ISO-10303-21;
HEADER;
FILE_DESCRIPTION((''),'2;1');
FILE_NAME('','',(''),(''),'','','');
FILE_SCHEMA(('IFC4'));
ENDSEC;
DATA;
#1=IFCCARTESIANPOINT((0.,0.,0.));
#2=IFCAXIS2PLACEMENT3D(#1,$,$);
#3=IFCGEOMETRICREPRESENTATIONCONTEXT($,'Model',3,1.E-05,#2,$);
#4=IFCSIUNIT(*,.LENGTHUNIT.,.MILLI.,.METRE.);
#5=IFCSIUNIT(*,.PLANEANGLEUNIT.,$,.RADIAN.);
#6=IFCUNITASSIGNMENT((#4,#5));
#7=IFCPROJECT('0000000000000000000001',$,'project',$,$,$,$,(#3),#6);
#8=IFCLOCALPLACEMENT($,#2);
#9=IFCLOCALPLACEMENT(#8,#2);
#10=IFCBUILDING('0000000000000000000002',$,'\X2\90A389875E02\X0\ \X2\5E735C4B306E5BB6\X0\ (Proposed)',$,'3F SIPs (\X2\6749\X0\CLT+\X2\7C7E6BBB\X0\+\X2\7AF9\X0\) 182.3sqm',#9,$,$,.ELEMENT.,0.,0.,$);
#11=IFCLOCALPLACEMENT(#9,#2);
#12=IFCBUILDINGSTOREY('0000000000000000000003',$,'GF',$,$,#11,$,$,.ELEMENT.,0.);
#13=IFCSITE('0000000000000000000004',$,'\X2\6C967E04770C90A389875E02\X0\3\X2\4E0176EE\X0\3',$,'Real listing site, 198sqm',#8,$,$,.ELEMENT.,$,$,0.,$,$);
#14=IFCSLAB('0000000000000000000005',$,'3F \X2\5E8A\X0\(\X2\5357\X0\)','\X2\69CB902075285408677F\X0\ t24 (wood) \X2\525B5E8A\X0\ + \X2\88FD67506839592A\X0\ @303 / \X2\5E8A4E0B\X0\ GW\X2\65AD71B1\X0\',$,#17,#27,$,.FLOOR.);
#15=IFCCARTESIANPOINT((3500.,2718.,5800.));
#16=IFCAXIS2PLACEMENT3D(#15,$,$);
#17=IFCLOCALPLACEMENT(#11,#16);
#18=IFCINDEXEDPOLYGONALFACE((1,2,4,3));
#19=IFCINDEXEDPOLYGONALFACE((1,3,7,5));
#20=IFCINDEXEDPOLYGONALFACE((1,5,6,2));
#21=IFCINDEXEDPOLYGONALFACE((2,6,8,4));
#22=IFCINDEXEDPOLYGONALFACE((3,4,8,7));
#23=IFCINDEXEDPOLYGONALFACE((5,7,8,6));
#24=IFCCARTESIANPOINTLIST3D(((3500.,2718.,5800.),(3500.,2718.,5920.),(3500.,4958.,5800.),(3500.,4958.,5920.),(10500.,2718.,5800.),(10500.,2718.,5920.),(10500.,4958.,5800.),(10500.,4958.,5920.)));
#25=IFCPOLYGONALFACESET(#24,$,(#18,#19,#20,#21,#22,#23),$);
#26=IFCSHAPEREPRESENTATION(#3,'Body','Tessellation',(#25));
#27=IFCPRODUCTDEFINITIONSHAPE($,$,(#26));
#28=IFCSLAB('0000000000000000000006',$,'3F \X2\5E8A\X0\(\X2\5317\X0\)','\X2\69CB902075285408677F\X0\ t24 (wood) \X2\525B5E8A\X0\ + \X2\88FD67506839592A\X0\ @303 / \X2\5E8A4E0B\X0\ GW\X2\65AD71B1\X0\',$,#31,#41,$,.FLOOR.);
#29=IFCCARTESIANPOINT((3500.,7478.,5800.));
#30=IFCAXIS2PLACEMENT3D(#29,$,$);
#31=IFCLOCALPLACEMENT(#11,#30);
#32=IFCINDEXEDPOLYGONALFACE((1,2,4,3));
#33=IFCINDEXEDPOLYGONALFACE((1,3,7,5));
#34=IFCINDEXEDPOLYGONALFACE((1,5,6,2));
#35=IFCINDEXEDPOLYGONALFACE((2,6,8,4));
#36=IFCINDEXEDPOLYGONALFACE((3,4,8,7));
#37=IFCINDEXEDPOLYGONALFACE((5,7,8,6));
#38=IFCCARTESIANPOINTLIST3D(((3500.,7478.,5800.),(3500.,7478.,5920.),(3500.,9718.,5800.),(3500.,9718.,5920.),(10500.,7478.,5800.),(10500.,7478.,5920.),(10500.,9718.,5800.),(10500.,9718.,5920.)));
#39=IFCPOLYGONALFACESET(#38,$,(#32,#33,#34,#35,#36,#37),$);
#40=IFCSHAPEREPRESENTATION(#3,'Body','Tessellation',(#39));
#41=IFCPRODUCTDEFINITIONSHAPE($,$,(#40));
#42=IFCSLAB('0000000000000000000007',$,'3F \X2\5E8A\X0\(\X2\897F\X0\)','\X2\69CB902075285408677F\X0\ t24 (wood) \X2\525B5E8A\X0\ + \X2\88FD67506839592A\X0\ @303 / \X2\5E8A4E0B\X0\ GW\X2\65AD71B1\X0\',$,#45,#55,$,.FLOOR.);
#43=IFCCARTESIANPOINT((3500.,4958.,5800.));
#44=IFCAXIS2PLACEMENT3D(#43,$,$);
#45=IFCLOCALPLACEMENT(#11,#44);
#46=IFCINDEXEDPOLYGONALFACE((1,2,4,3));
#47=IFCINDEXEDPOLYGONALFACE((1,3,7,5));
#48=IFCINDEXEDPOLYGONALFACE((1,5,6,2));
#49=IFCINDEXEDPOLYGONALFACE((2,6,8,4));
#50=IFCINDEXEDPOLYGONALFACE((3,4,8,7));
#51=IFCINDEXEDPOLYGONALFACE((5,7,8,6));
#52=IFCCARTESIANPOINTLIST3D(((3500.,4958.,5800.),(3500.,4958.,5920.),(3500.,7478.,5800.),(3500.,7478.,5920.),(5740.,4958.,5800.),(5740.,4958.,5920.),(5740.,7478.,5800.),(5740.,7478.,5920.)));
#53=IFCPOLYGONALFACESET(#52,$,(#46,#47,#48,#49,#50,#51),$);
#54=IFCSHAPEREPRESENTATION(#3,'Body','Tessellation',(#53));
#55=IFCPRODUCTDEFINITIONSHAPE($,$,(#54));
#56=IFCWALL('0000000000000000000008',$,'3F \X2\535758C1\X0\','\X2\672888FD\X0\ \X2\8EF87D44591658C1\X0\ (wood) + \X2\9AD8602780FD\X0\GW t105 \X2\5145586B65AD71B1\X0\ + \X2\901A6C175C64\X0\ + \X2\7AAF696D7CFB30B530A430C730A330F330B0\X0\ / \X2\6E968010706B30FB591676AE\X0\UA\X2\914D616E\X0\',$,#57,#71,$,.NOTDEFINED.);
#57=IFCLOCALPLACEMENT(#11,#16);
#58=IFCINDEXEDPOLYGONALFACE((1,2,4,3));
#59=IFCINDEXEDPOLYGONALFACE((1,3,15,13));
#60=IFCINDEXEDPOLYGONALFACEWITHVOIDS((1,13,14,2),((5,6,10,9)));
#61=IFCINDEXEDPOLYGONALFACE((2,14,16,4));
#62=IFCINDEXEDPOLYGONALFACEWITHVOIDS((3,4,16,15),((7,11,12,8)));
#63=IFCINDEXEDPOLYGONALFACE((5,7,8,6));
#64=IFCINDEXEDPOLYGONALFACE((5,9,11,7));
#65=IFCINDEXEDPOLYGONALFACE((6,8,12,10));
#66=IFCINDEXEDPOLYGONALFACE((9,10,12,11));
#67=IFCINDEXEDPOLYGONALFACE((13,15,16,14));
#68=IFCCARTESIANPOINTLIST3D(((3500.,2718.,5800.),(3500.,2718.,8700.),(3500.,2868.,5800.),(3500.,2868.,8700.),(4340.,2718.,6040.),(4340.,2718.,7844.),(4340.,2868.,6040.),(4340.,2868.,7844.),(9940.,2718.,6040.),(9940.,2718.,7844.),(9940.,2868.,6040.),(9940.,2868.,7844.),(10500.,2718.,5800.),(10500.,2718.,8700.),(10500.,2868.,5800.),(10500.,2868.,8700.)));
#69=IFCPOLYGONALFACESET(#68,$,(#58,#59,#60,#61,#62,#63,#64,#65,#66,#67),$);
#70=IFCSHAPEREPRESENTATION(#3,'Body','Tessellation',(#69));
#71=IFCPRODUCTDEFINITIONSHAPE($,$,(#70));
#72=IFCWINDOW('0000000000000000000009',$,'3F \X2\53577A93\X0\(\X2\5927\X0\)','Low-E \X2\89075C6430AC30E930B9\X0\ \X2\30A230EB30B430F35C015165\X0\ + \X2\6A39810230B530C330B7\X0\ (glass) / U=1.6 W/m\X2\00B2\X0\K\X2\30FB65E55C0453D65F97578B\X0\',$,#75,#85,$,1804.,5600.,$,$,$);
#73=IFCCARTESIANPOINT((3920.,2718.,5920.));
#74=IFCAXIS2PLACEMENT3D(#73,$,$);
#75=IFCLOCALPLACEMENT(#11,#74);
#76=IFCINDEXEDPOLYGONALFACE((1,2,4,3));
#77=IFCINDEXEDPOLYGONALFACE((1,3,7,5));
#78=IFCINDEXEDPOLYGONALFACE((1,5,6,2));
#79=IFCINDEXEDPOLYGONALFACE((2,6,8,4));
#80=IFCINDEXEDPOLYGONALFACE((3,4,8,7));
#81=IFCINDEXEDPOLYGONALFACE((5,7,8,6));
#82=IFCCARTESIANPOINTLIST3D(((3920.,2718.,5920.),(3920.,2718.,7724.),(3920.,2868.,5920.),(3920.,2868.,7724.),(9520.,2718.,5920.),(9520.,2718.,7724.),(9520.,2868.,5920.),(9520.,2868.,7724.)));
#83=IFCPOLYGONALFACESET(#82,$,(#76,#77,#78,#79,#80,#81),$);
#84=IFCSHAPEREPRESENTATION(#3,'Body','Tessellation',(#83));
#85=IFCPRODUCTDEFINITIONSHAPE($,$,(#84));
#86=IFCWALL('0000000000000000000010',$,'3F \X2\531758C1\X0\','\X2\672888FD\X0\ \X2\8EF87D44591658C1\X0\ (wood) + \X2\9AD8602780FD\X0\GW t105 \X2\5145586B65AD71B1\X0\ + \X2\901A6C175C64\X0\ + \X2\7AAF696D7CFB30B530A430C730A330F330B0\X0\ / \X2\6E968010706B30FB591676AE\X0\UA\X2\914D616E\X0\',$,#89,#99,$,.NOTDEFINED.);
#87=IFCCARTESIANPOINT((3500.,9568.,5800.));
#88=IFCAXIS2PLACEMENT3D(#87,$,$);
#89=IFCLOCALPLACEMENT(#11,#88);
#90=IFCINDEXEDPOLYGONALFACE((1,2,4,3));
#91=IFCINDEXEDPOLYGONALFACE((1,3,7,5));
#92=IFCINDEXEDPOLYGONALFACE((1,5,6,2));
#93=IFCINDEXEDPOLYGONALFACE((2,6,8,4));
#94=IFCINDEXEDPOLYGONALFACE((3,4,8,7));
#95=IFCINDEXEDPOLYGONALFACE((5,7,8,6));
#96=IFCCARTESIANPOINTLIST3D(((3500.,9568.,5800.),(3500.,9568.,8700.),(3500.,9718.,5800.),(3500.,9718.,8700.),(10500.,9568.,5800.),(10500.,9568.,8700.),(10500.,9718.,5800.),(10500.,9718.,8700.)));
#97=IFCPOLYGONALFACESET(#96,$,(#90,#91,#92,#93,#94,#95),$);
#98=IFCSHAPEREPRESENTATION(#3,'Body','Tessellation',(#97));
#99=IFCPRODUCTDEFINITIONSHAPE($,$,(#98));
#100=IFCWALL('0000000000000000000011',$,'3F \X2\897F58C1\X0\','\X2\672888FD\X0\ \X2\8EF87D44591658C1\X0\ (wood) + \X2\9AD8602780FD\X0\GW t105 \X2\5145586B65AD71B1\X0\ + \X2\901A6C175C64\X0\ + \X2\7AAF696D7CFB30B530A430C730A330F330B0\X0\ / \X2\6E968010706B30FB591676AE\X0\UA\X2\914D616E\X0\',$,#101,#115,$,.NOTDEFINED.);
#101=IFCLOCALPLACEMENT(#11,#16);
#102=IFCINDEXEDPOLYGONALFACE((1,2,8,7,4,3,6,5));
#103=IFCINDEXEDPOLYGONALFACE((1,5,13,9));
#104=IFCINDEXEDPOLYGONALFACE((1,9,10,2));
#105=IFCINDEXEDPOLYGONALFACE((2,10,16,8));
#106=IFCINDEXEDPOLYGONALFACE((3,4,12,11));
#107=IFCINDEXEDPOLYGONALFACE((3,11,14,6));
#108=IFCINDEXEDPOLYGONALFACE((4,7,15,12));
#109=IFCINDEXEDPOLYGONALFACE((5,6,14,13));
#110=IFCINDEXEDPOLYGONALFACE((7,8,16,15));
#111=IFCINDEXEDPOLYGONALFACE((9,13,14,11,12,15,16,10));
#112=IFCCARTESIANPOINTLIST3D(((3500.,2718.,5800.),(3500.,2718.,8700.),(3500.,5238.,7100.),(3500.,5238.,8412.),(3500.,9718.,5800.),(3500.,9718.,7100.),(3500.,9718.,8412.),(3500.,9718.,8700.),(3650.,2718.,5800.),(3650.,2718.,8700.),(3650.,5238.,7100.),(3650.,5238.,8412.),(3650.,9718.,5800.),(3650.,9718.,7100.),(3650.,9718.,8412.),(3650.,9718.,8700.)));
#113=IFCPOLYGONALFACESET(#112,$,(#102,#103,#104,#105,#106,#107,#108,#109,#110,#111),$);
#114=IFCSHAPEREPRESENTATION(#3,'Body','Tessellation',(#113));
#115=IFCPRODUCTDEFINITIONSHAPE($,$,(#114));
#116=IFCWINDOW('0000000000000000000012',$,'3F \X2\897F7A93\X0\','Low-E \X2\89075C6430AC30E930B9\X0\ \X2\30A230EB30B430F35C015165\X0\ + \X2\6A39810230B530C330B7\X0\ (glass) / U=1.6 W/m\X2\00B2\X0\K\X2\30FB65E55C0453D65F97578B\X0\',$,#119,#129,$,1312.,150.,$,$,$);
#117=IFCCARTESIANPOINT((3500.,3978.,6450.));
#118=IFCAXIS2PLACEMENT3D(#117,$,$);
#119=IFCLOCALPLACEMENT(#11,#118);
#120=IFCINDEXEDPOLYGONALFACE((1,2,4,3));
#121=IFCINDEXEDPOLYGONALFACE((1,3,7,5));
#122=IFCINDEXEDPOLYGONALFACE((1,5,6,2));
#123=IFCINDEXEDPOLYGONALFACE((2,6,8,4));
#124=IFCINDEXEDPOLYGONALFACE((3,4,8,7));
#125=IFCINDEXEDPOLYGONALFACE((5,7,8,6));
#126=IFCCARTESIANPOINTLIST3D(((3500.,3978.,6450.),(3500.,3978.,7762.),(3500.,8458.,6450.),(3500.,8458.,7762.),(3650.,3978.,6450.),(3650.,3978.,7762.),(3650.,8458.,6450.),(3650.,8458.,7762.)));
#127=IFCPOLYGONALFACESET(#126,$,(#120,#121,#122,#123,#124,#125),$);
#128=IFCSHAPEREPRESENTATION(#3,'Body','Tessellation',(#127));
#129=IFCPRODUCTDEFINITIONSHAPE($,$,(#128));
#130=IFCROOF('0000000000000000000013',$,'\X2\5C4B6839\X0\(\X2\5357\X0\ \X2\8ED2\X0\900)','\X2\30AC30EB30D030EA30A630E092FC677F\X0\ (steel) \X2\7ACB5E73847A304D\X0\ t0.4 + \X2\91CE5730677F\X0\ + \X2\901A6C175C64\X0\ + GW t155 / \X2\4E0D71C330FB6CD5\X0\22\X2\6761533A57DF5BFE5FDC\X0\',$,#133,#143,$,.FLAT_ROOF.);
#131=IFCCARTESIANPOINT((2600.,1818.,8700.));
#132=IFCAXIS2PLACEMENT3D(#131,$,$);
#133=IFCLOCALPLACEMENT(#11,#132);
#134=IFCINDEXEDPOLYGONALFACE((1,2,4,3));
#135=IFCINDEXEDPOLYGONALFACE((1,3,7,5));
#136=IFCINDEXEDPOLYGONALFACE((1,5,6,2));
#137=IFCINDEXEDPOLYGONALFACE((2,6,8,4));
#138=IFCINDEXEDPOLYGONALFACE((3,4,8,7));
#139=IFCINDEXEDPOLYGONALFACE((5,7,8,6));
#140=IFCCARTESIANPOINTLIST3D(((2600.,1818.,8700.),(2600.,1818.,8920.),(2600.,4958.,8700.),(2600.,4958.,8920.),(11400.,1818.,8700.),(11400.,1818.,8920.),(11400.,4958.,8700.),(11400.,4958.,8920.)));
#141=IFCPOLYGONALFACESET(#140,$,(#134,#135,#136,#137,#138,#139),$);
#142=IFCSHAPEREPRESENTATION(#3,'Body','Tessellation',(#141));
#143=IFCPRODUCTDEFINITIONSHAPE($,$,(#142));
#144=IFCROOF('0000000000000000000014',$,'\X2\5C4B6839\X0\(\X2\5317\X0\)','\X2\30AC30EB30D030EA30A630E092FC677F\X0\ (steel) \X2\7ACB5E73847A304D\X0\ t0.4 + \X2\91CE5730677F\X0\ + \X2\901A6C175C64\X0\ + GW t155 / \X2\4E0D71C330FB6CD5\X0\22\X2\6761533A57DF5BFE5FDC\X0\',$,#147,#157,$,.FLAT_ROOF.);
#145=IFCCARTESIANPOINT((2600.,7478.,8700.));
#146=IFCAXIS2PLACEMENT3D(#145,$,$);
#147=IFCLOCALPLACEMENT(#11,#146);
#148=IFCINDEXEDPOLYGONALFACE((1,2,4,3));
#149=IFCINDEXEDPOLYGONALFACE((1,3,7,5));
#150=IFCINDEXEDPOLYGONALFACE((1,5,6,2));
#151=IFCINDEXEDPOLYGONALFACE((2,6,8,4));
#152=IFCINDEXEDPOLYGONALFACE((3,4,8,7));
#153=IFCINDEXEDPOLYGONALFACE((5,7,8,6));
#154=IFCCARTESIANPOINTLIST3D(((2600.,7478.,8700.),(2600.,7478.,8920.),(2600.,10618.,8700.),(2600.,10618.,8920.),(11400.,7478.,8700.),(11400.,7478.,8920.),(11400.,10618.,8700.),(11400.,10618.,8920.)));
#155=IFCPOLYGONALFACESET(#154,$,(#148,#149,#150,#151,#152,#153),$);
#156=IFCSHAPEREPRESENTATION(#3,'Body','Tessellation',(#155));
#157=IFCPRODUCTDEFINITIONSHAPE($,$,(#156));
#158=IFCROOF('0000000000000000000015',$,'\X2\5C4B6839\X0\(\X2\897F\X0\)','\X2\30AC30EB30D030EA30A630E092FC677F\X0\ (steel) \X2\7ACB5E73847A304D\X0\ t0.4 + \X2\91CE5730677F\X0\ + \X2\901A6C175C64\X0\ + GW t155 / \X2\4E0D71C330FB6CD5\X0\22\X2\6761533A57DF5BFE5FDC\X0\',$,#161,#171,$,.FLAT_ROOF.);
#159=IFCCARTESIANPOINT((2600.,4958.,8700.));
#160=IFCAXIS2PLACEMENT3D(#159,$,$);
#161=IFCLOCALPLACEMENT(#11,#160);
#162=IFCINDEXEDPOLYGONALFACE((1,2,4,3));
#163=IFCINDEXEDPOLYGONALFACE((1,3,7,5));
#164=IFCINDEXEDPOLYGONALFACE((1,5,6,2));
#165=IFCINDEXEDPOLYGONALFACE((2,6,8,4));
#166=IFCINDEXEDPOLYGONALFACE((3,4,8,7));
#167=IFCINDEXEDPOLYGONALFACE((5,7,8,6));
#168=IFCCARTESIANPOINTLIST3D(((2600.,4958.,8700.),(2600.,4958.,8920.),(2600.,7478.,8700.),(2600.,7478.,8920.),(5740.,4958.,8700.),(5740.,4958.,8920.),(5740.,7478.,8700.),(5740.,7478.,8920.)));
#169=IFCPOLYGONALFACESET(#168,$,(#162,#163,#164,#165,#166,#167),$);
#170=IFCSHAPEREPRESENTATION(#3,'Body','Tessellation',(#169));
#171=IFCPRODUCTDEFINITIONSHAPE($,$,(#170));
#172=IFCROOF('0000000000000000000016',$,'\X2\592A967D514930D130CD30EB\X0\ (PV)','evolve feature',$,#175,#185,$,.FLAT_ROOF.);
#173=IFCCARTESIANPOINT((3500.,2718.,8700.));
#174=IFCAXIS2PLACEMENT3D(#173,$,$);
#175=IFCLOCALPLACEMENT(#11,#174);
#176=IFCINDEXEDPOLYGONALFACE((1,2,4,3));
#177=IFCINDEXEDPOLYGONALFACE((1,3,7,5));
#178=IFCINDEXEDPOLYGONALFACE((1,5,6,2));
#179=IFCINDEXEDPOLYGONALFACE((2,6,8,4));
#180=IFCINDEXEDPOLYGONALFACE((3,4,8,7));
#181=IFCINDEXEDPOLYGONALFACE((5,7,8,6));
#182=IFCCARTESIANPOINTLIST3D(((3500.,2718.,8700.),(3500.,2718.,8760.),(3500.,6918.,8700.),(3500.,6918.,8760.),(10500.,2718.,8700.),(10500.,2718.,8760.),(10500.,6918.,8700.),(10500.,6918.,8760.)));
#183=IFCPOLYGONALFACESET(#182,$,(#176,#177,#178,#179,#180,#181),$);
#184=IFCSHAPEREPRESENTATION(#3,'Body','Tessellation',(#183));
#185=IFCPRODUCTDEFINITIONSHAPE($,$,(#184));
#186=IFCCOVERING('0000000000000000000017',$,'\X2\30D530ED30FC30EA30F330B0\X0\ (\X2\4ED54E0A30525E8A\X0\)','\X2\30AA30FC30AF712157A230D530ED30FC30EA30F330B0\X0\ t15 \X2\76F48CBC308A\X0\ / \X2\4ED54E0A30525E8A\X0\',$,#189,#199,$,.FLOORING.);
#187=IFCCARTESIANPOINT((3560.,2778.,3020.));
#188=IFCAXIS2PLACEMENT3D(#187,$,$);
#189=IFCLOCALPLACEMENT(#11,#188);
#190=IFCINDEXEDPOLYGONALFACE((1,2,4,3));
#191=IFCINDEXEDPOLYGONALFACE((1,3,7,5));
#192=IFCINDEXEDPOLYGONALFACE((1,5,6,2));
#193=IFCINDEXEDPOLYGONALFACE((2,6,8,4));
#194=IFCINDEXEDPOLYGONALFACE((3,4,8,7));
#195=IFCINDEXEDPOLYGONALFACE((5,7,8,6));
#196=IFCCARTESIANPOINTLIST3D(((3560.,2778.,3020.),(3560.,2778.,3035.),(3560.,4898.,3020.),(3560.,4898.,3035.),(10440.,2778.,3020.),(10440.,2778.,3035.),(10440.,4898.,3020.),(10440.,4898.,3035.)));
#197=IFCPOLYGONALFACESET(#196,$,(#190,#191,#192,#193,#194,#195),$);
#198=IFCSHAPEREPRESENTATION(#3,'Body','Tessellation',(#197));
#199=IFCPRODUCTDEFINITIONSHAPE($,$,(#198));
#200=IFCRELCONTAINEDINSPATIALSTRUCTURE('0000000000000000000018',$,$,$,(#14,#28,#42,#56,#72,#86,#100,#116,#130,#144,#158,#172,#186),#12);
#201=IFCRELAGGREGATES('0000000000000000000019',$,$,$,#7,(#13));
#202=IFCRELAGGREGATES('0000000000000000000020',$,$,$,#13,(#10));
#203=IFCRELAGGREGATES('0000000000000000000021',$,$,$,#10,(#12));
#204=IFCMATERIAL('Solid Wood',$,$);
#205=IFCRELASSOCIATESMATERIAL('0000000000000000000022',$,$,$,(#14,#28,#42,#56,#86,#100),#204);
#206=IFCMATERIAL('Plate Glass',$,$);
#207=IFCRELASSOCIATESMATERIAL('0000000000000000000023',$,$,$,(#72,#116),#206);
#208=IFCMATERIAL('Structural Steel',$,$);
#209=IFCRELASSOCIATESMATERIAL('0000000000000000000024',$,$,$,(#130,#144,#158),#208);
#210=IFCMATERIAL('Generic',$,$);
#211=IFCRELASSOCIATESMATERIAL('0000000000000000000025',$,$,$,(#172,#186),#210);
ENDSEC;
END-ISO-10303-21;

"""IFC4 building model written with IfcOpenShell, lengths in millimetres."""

from ifc_helpers import new_model, si_unit, frame, frame_2d, origin, place, context, project, spatial, rectangle, extrude, material, element, fill, save


model = new_model("IFC4")

# Units and contexts
model_context = context("Model", 3, precision=1e-05, world=origin())
ifc_project = project(units=[si_unit("LENGTHUNIT", "METRE", prefix="MILLI"), si_unit("PLANEANGLEUNIT", "RADIAN")], contexts=[model_context])

# Site, building, storey
site_placement = place(None, origin())
site = spatial("IfcSite", under=ifc_project, at=site_placement, Name="沖縄県那覇市3丁目3", ObjectType="Real listing site, 198sqm", CompositionType="ELEMENT", RefElevation=0.0)
building_placement = place(site_placement, origin())
building = spatial("IfcBuilding", under=site, at=building_placement, Name="那覇市 平屋の家 (Proposed)", ObjectType="3F SIPs (杉CLT+籾殻+竹) 182.3sqm", CompositionType="ELEMENT", ElevationOfRefHeight=0.0, ElevationOfTerrain=0.0)
storey_placement = place(building_placement, origin())
storey = spatial("IfcBuildingStorey", under=building, at=storey_placement, Name="GF", CompositionType="ELEMENT", Elevation=0.0)

# Slabs
ifc_material_1 = material(Name="Solid Wood")
slab_1_placement = place(storey_placement, frame((3500.0, 2718.0, 5800.0)))
element("IfcSlab", 1, at=slab_1_placement, inside=storey, material=ifc_material_1, Name="3F 床(南)", Description="構造用合板 t24 (wood) 剛床 + 製材根太 @303 / 床下 GW断熱", PredefinedType="FLOOR", context=model_context, shape_type="SweptSolid", body=[
    extrude(rectangle(XDim=7000.0, YDim=2240.0, at=frame_2d((3500.0, 1120.0))), frame((3500.0, 2718.0, 5800.0)), (0.0, 0.0, 1.0), 120.0),
])
slab_2_placement = place(storey_placement, frame((3500.0, 7478.0, 5800.0)))
element("IfcSlab", 2, at=slab_2_placement, inside=storey, material=ifc_material_1, Name="3F 床(北)", Description="構造用合板 t24 (wood) 剛床 + 製材根太 @303 / 床下 GW断熱", PredefinedType="FLOOR", context=model_context, shape_type="SweptSolid", body=[
    extrude(rectangle(XDim=7000.0, YDim=2240.0, at=frame_2d((3500.0, 1120.0))), frame((3500.0, 7478.0, 5800.0)), (0.0, 0.0, 1.0), 120.0),
])
slab_3_placement = place(storey_placement, frame((3500.0, 4958.0, 5800.0)))
element("IfcSlab", 3, at=slab_3_placement, inside=storey, material=ifc_material_1, Name="3F 床(西)", Description="構造用合板 t24 (wood) 剛床 + 製材根太 @303 / 床下 GW断熱", PredefinedType="FLOOR", context=model_context, shape_type="SweptSolid", body=[
    extrude(rectangle(XDim=2240.0, YDim=2520.0, at=frame_2d((1120.0, 1260.0))), frame((3500.0, 4958.0, 5800.0)), (0.0, 0.0, 1.0), 120.0),
])

# Wall, opening, window
wall_1_placement = place(storey_placement, frame((3500.0, 2718.0, 5800.0)))
wall_1 = element("IfcWall", 4, at=wall_1_placement, inside=storey, material=ifc_material_1, Name="3F 南壁", Description="木製 軸組外壁 (wood) + 高性能GW t105 充填断熱 + 通気層 + 窯業系サイディング / 準耐火・外皮UA配慮", PredefinedType="NOTDEFINED", context=model_context, shape_type="SweptSolid", body=[
    extrude(rectangle(XDim=7000.0, YDim=150.0, at=frame_2d((3500.0, 75.0))), frame((3500.0, 2718.0, 5800.0)), (0.0, 0.0, 1.0), 2900.0),
])
opening_1_placement = place(storey_placement, frame((3920.0, 2718.0, 5920.0)))
opening_1 = element("IfcOpeningElement", 5, at=opening_1_placement, cuts=wall_1, PredefinedType="NOTDEFINED", context=model_context, shape_type="SweptSolid", body=[
    extrude(rectangle(XDim=5600.0, YDim=150.0, at=frame_2d((2800.0, 75.0))), frame((3920.0, 2718.0, 5920.0)), (0.0, 0.0, 1.0), 1804.0),
])
ifc_material_2 = material(Name="Plate Glass")
window_1_placement = place(storey_placement, frame((3920.0, 2718.0, 5920.0)))
window_1 = element("IfcWindow", 6, at=window_1_placement, inside=storey, material=ifc_material_2, Name="3F 南窓(大)", Description="Low-E 複層ガラス アルゴン封入 + 樹脂サッシ (glass) / U=1.6 W/m²K・日射取得型", OverallHeight=1804.0, OverallWidth=5600.0, context=model_context, shape_type="SweptSolid", body=[
    extrude(rectangle(XDim=5600.0, YDim=150.0, at=frame_2d((2800.0, 75.0))), frame((3920.0, 2718.0, 5920.0)), (0.0, 0.0, 1.0), 1804.0),
])
fill(opening_1, window_1)

# Wall
wall_2_placement = place(storey_placement, frame((3500.0, 9568.0, 5800.0)))
element("IfcWall", 7, at=wall_2_placement, inside=storey, material=ifc_material_1, Name="3F 北壁", Description="木製 軸組外壁 (wood) + 高性能GW t105 充填断熱 + 通気層 + 窯業系サイディング / 準耐火・外皮UA配慮", PredefinedType="NOTDEFINED", context=model_context, shape_type="SweptSolid", body=[
    extrude(rectangle(XDim=7000.0, YDim=150.0, at=frame_2d((3500.0, 75.0))), frame((3500.0, 9568.0, 5800.0)), (0.0, 0.0, 1.0), 2900.0),
])

# Wall, opening, window
wall_3_placement = place(storey_placement, frame((3500.0, 2718.0, 5800.0)))
wall_3 = element("IfcWall", 8, at=wall_3_placement, inside=storey, material=ifc_material_1, Name="3F 西壁", Description="木製 軸組外壁 (wood) + 高性能GW t105 充填断熱 + 通気層 + 窯業系サイディング / 準耐火・外皮UA配慮", PredefinedType="NOTDEFINED", context=model_context, shape_type="SweptSolid", body=[
    extrude(rectangle(XDim=150.0, YDim=7000.0, at=frame_2d((75.0, 3500.0))), frame((3500.0, 2718.0, 5800.0)), (0.0, 0.0, 1.0), 2900.0),
])
opening_2_placement = place(storey_placement, frame((3500.0, 3978.0, 6450.0)))
opening_2 = element("IfcOpeningElement", 9, at=opening_2_placement, cuts=wall_3, PredefinedType="NOTDEFINED", context=model_context, shape_type="SweptSolid", body=[
    extrude(rectangle(XDim=150.0, YDim=4480.0, at=frame_2d((75.0, 2240.0))), frame((3500.0, 3978.0, 6450.0)), (0.0, 0.0, 1.0), 1312.0),
])
window_2_placement = place(storey_placement, frame((3500.0, 3978.0, 6450.0)))
window_2 = element("IfcWindow", 10, at=window_2_placement, inside=storey, material=ifc_material_2, Name="3F 西窓", Description="Low-E 複層ガラス アルゴン封入 + 樹脂サッシ (glass) / U=1.6 W/m²K・日射取得型", OverallHeight=1312.0, OverallWidth=150.0, context=model_context, shape_type="SweptSolid", body=[
    extrude(rectangle(XDim=150.0, YDim=4480.0, at=frame_2d((75.0, 2240.0))), frame((3500.0, 3978.0, 6450.0)), (0.0, 0.0, 1.0), 1312.0),
])
fill(opening_2, window_2)

# Roofs
ifc_material_3 = material(Name="Structural Steel")
roof_1_placement = place(storey_placement, frame((2600.0, 1818.0, 8700.0)))
element("IfcRoof", 11, at=roof_1_placement, inside=storey, material=ifc_material_3, Name="屋根(南 軒900)", Description="ガルバリウム鋼板 (steel) 立平葺き t0.4 + 野地板 + 通気層 + GW t155 / 不燃・法22条区域対応", PredefinedType="FLAT_ROOF", context=model_context, shape_type="SweptSolid", body=[
    extrude(rectangle(XDim=8800.0, YDim=3140.0, at=frame_2d((4400.0, 1570.0))), frame((2600.0, 1818.0, 8700.0)), (0.0, 0.0, 1.0), 220.0),
])
roof_2_placement = place(storey_placement, frame((2600.0, 7478.0, 8700.0)))
element("IfcRoof", 12, at=roof_2_placement, inside=storey, material=ifc_material_3, Name="屋根(北)", Description="ガルバリウム鋼板 (steel) 立平葺き t0.4 + 野地板 + 通気層 + GW t155 / 不燃・法22条区域対応", PredefinedType="FLAT_ROOF", context=model_context, shape_type="SweptSolid", body=[
    extrude(rectangle(XDim=8800.0, YDim=3140.0, at=frame_2d((4400.0, 1570.0))), frame((2600.0, 7478.0, 8700.0)), (0.0, 0.0, 1.0), 220.0),
])
roof_3_placement = place(storey_placement, frame((2600.0, 4958.0, 8700.0)))
element("IfcRoof", 13, at=roof_3_placement, inside=storey, material=ifc_material_3, Name="屋根(西)", Description="ガルバリウム鋼板 (steel) 立平葺き t0.4 + 野地板 + 通気層 + GW t155 / 不燃・法22条区域対応", PredefinedType="FLAT_ROOF", context=model_context, shape_type="SweptSolid", body=[
    extrude(rectangle(XDim=3140.0, YDim=2520.0, at=frame_2d((1570.0, 1260.0))), frame((2600.0, 4958.0, 8700.0)), (0.0, 0.0, 1.0), 220.0),
])
ifc_material_4 = material(Name="Generic")
roof_4_placement = place(storey_placement, frame((3500.0, 2718.0, 8700.0)))
element("IfcRoof", 14, at=roof_4_placement, inside=storey, material=ifc_material_4, Name="太陽光パネル (PV)", Description="evolve feature", PredefinedType="FLAT_ROOF", context=model_context, shape_type="SweptSolid", body=[
    extrude(rectangle(XDim=7000.0, YDim=4200.0, at=frame_2d((3500.0, 2100.0))), frame((3500.0, 2718.0, 8700.0)), (0.0, 0.0, 1.0), 60.0),
])

# Covering
covering_1_placement = place(storey_placement, frame((3560.0, 2778.0, 3020.0)))
element("IfcCovering", 15, at=covering_1_placement, inside=storey, material=ifc_material_4, Name="フローリング (仕上げ床)", Description="オーク無垢フローリング t15 直貼り / 仕上げ床", PredefinedType="FLOORING", context=model_context, shape_type="SweptSolid", body=[
    extrude(rectangle(XDim=6880.0, YDim=2120.0, at=frame_2d((3440.0, 1060.0))), frame((3560.0, 2778.0, 3020.0)), (0.0, 0.0, 1.0), 15.0),
])

save(model, "model.ifc")
